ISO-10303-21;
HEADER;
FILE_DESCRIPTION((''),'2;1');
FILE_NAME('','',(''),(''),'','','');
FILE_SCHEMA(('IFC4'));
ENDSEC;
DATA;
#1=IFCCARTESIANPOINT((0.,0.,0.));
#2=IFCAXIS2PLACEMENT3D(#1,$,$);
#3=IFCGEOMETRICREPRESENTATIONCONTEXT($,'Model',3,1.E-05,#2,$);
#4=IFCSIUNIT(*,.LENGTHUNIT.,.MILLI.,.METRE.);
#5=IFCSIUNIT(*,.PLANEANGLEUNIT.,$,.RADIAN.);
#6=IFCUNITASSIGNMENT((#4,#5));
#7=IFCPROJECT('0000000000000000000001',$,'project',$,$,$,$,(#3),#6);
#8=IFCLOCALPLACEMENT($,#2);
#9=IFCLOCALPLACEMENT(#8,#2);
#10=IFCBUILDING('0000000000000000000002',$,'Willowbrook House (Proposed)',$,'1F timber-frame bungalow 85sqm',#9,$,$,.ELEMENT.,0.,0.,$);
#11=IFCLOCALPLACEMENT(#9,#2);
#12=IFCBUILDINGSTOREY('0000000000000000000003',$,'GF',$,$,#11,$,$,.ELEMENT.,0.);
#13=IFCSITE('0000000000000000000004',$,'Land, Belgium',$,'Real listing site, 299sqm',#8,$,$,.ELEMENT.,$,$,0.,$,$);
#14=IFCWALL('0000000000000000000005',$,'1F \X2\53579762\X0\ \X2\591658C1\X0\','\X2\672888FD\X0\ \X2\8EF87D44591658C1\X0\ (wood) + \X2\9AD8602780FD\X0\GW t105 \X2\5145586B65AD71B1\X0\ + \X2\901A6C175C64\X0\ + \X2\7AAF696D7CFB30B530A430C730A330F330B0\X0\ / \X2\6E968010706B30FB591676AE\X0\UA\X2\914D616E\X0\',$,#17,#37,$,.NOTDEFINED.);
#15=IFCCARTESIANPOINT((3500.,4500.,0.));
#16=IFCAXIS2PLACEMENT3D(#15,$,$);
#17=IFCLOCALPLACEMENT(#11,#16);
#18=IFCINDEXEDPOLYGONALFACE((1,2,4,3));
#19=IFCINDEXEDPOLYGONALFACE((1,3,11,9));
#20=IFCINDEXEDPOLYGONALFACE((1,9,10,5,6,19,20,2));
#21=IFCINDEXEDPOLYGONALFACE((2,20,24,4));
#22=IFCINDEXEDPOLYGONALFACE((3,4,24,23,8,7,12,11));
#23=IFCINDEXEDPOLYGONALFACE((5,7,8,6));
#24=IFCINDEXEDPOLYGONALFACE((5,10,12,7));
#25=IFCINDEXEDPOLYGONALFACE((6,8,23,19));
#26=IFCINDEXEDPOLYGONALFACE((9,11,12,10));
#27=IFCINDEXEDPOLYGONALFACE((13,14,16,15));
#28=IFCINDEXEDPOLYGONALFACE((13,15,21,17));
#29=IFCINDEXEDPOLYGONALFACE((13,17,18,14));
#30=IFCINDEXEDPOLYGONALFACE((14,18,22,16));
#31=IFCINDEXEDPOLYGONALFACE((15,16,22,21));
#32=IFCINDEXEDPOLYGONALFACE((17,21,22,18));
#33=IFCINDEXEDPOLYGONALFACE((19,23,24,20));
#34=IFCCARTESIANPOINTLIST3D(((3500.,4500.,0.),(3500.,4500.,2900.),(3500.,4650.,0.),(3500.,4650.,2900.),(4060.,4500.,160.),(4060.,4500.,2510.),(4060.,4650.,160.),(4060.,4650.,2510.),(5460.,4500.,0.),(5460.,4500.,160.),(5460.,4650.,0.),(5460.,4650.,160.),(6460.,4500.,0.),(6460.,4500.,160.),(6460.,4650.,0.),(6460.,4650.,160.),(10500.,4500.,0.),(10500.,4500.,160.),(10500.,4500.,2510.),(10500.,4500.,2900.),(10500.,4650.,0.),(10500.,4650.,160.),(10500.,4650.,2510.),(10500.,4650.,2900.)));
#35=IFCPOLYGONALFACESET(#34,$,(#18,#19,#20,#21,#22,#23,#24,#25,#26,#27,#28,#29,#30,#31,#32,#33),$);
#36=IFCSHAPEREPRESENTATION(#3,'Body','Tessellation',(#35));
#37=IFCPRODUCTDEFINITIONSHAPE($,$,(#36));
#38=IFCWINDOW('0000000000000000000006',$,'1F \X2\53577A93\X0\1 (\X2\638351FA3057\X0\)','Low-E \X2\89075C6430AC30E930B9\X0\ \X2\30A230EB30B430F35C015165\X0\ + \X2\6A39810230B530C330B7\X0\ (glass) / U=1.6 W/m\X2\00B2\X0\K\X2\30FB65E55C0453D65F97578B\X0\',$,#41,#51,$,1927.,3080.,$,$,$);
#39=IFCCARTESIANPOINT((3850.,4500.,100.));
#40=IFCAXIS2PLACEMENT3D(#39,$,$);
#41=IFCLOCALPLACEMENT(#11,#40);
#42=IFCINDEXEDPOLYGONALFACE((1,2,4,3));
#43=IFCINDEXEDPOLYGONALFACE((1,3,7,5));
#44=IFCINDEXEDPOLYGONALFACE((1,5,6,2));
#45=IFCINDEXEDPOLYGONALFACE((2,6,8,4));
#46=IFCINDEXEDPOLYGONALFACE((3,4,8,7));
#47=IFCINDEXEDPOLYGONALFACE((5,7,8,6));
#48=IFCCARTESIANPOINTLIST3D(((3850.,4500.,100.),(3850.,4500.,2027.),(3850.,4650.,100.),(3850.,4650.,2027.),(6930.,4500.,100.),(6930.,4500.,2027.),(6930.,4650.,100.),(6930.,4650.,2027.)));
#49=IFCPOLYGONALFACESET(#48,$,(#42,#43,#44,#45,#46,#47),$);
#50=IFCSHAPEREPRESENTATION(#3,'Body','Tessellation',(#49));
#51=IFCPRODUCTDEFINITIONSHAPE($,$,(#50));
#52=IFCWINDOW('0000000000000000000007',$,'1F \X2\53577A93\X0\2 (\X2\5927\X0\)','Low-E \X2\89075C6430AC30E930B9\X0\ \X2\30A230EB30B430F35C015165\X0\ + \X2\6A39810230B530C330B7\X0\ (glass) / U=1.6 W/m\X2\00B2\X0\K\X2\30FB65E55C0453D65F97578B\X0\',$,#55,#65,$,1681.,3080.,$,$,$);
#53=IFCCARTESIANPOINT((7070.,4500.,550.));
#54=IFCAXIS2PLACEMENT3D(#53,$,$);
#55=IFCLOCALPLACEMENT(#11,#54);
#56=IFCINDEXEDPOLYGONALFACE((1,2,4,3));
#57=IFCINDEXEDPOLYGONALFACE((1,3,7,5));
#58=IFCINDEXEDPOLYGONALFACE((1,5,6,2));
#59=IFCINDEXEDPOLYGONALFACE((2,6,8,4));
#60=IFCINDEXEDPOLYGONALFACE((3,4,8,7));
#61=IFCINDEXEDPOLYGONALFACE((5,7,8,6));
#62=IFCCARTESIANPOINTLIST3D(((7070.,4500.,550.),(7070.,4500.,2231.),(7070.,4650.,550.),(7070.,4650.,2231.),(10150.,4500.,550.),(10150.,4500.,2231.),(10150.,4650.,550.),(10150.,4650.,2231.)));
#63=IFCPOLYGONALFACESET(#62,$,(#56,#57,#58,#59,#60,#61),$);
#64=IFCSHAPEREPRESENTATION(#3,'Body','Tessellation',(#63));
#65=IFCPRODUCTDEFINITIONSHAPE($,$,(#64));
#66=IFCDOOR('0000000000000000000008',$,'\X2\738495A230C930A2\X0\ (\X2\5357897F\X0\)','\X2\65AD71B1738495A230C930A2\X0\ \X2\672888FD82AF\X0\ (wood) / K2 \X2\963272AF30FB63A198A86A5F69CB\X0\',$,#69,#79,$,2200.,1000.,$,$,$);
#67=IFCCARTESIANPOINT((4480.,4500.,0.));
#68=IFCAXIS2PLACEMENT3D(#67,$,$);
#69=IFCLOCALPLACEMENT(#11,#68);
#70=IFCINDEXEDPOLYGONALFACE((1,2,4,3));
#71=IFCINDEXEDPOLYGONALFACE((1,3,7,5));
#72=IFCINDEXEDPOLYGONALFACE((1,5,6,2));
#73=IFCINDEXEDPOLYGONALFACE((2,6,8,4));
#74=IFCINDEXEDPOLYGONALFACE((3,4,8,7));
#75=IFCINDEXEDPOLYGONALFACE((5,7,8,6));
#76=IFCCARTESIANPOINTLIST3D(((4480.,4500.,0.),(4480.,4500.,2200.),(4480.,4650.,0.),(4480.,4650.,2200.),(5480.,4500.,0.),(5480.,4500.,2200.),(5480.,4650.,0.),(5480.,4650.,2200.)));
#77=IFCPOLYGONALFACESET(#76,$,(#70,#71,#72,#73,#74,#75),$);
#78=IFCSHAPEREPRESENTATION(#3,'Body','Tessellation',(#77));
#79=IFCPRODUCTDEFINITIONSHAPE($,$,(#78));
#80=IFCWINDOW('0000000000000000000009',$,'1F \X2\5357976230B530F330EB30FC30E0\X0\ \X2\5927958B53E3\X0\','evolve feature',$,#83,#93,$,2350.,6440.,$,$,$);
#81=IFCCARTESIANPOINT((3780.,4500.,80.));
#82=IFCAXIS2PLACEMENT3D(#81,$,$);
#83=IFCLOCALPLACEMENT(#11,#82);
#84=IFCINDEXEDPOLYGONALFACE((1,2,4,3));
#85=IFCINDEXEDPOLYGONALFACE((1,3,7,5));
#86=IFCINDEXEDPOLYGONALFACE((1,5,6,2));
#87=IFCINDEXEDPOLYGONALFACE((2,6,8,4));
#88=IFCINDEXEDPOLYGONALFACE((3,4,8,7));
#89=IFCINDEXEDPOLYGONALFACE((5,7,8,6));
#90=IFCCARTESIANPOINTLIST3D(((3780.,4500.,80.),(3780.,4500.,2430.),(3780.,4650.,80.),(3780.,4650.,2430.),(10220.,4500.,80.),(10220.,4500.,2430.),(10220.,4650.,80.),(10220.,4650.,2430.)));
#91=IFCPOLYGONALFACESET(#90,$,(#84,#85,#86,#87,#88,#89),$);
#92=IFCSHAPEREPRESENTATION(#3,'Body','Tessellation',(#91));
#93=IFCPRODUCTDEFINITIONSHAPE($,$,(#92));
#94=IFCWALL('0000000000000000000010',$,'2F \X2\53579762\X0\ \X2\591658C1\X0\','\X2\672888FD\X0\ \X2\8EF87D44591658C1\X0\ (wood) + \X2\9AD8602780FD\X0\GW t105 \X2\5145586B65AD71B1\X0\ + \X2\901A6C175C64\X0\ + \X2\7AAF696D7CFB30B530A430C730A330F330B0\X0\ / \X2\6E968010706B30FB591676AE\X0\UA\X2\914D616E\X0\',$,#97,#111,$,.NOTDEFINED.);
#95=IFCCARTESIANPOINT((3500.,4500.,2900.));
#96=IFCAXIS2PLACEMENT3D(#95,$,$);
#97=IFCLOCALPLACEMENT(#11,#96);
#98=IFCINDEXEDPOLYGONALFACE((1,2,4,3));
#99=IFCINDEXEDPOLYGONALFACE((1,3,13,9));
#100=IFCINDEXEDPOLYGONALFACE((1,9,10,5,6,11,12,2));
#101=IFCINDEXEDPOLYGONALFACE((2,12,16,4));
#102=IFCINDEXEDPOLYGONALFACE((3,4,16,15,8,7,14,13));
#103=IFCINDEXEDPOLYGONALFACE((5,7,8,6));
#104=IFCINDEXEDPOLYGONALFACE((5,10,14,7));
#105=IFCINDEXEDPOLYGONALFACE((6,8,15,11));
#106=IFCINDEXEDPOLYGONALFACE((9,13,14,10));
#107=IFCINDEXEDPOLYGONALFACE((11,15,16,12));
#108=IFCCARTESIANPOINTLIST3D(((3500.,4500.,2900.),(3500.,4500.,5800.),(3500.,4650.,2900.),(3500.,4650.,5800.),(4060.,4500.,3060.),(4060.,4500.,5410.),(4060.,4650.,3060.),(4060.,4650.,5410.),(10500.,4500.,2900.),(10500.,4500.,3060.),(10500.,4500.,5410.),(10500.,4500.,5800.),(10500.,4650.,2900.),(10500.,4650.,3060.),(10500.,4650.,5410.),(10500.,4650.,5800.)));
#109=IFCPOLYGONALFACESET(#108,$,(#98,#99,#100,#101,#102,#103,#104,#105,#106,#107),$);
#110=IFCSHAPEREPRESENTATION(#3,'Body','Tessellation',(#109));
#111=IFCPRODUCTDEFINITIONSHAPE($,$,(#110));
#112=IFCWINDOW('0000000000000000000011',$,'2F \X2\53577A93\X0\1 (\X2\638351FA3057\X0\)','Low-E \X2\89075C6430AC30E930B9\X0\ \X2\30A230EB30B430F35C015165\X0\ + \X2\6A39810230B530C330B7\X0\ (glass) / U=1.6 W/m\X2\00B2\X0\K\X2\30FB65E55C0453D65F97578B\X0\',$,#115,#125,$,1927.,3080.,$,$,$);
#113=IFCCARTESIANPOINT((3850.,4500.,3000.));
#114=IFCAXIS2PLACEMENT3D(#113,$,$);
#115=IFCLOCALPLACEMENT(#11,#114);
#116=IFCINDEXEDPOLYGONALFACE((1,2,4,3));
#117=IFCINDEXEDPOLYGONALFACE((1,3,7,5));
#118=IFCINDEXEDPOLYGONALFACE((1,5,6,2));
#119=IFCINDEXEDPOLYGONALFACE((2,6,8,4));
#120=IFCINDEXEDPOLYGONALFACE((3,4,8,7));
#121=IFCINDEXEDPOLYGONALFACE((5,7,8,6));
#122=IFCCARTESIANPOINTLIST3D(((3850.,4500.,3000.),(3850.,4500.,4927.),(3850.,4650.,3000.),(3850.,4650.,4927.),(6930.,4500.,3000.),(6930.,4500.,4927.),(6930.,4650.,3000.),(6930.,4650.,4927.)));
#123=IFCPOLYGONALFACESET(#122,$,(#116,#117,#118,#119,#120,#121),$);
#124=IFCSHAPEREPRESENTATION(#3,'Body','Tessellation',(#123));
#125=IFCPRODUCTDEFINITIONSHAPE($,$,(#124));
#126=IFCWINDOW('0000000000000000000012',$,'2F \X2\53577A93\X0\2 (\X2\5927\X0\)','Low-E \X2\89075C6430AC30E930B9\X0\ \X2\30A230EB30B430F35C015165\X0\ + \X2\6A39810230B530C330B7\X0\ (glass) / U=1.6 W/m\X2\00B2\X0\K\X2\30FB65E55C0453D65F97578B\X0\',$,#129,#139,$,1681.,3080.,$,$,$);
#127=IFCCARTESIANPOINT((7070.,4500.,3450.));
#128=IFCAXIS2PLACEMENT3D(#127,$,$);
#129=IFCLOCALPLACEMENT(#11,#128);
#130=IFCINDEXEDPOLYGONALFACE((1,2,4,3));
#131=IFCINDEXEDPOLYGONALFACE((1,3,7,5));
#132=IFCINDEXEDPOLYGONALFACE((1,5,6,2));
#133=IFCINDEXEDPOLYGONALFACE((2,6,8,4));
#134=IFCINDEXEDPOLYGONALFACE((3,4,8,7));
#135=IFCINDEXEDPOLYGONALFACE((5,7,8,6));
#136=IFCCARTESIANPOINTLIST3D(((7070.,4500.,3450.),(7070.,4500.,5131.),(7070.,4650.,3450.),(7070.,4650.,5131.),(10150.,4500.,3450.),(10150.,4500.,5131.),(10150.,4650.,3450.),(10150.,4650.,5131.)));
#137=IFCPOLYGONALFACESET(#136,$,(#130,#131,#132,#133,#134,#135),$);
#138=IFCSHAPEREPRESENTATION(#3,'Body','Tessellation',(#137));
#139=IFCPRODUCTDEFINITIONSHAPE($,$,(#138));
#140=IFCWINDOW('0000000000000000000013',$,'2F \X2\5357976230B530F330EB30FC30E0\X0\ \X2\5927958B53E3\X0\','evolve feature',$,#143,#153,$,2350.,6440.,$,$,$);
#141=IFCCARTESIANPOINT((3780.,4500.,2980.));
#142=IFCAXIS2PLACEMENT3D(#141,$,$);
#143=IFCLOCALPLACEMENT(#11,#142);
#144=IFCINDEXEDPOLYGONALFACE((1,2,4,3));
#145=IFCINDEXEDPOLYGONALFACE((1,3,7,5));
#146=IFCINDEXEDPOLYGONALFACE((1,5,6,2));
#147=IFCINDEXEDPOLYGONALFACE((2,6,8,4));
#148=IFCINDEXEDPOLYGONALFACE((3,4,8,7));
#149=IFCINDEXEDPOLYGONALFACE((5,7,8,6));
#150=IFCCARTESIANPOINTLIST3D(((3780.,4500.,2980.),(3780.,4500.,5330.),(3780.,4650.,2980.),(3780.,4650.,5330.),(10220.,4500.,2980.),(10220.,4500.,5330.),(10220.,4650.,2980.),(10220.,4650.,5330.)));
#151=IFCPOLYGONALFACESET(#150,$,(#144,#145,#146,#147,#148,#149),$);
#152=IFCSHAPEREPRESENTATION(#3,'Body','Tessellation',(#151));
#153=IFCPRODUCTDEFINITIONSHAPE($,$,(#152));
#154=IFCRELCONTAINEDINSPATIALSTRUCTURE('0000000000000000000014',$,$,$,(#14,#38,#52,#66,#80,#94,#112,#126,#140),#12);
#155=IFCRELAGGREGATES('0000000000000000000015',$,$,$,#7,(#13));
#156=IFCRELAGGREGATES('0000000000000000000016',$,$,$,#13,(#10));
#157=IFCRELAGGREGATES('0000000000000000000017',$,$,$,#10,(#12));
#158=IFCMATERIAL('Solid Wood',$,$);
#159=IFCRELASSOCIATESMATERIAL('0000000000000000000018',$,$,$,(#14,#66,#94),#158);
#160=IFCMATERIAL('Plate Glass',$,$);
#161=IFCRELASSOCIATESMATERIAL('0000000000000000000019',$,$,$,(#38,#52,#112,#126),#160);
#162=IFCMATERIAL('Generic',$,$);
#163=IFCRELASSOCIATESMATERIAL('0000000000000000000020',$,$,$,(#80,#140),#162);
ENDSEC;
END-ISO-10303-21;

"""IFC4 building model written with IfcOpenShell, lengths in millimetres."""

from ifc_helpers import new_model, si_unit, frame, frame_2d, origin, place, context, project, spatial, rectangle, extrude, material, element, fill, save


model = new_model("IFC4")

# Units and contexts
model_context = context("Model", 3, precision=1e-05, world=origin())
ifc_project = project(units=[si_unit("LENGTHUNIT", "METRE", prefix="MILLI"), si_unit("PLANEANGLEUNIT", "RADIAN")], contexts=[model_context])

# Site, building, storey
site_placement = place(None, origin())
site = spatial("IfcSite", under=ifc_project, at=site_placement, Name="Land, Belgium", ObjectType="Real listing site, 299sqm", CompositionType="ELEMENT", RefElevation=0.0)
building_placement = place(site_placement, origin())
building = spatial("IfcBuilding", under=site, at=building_placement, Name="Willowbrook House (Proposed)", ObjectType="1F timber-frame bungalow 85sqm", CompositionType="ELEMENT", ElevationOfRefHeight=0.0, ElevationOfTerrain=0.0)
storey_placement = place(building_placement, origin())
storey = spatial("IfcBuildingStorey", under=building, at=storey_placement, Name="GF", CompositionType="ELEMENT", Elevation=0.0)

# Shared definitions
ifc_material_1 = material(Name="Solid Wood")
ifc_material_2 = material(Name="Generic")

# Wall, openings, windows, door
wall_1_placement = place(storey_placement, frame((3500.0, 4500.0, 0.0)))
wall_1 = element("IfcWall", 1, at=wall_1_placement, inside=storey, material=ifc_material_1, Name="1F 南面 外壁", Description="木製 軸組外壁 (wood) + 高性能GW t105 充填断熱 + 通気層 + 窯業系サイディング / 準耐火・外皮UA配慮", PredefinedType="NOTDEFINED", context=model_context, shape_type="SweptSolid", body=[
    extrude(rectangle(XDim=7000.0, YDim=150.0, at=frame_2d((3500.0, 75.0))), frame((3500.0, 4500.0, 0.0)), (0.0, 0.0, 1.0), 2900.0),
])
opening_1_placement = place(storey_placement, frame((3850.0, 4500.0, 100.0)))
opening_1 = element("IfcOpeningElement", 2, at=opening_1_placement, cuts=wall_1, PredefinedType="NOTDEFINED", context=model_context, shape_type="SweptSolid", body=[
    extrude(rectangle(XDim=3080.0, YDim=150.0, at=frame_2d((1540.0, 75.0))), frame((3850.0, 4500.0, 100.0)), (0.0, 0.0, 1.0), 1927.0),
])
opening_2_placement = place(storey_placement, frame((7070.0, 4500.0, 550.0)))
opening_2 = element("IfcOpeningElement", 3, at=opening_2_placement, cuts=wall_1, PredefinedType="NOTDEFINED", context=model_context, shape_type="SweptSolid", body=[
    extrude(rectangle(XDim=3080.0, YDim=150.0, at=frame_2d((1540.0, 75.0))), frame((7070.0, 4500.0, 550.0)), (0.0, 0.0, 1.0), 1681.0),
])
opening_3_placement = place(storey_placement, frame((4480.0, 4500.0, 0.0)))
opening_3 = element("IfcOpeningElement", 4, at=opening_3_placement, cuts=wall_1, PredefinedType="NOTDEFINED", context=model_context, shape_type="SweptSolid", body=[
    extrude(rectangle(XDim=1000.0, YDim=150.0, at=frame_2d((500.0, 75.0))), frame((4480.0, 4500.0, 0.0)), (0.0, 0.0, 1.0), 2200.0),
])
opening_4_placement = place(storey_placement, frame((3780.0, 4500.0, 80.0)))
opening_4 = element("IfcOpeningElement", 5, at=opening_4_placement, cuts=wall_1, PredefinedType="NOTDEFINED", context=model_context, shape_type="SweptSolid", body=[
    extrude(rectangle(XDim=6440.0, YDim=150.0, at=frame_2d((3220.0, 75.0))), frame((3780.0, 4500.0, 80.0)), (0.0, 0.0, 1.0), 2350.0),
])
ifc_material_3 = material(Name="Plate Glass")
window_1_placement = place(storey_placement, frame((3850.0, 4500.0, 100.0)))
window_1 = element("IfcWindow", 6, at=window_1_placement, inside=storey, material=ifc_material_3, Name="1F 南窓1 (掃出し)", Description="Low-E 複層ガラス アルゴン封入 + 樹脂サッシ (glass) / U=1.6 W/m²K・日射取得型", OverallHeight=1927.0, OverallWidth=3080.0, context=model_context, shape_type="SweptSolid", body=[
    extrude(rectangle(XDim=3080.0, YDim=150.0, at=frame_2d((1540.0, 75.0))), frame((3850.0, 4500.0, 100.0)), (0.0, 0.0, 1.0), 1927.0),
])
fill(opening_1, window_1)
window_2_placement = place(storey_placement, frame((7070.0, 4500.0, 550.0)))
window_2 = element("IfcWindow", 7, at=window_2_placement, inside=storey, material=ifc_material_3, Name="1F 南窓2 (大)", Description="Low-E 複層ガラス アルゴン封入 + 樹脂サッシ (glass) / U=1.6 W/m²K・日射取得型", OverallHeight=1681.0, OverallWidth=3080.0, context=model_context, shape_type="SweptSolid", body=[
    extrude(rectangle(XDim=3080.0, YDim=150.0, at=frame_2d((1540.0, 75.0))), frame((7070.0, 4500.0, 550.0)), (0.0, 0.0, 1.0), 1681.0),
])
fill(opening_2, window_2)
door_placement = place(storey_placement, frame((4480.0, 4500.0, 0.0)))
door = element("IfcDoor", 8, at=door_placement, inside=storey, material=ifc_material_1, Name="玄関ドア (南西)", Description="断熱玄関ドア 木製芯 (wood) / K2 防犯・採風機構", OverallHeight=2200.0, OverallWidth=1000.0, context=model_context, shape_type="SweptSolid", body=[
    extrude(rectangle(XDim=1000.0, YDim=150.0, at=frame_2d((500.0, 75.0))), frame((4480.0, 4500.0, 0.0)), (0.0, 0.0, 1.0), 2200.0),
])
fill(opening_3, door)
window_3_placement = place(storey_placement, frame((3780.0, 4500.0, 80.0)))
window_3 = element("IfcWindow", 9, at=window_3_placement, inside=storey, material=ifc_material_2, Name="1F 南面サンルーム 大開口", Description="evolve feature", OverallHeight=2350.0, OverallWidth=6440.0, context=model_context, shape_type="SweptSolid", body=[
    extrude(rectangle(XDim=6440.0, YDim=150.0, at=frame_2d((3220.0, 75.0))), frame((3780.0, 4500.0, 80.0)), (0.0, 0.0, 1.0), 2350.0),
])
fill(opening_4, window_3)

# Wall, openings, windows
wall_2_placement = place(storey_placement, frame((3500.0, 4500.0, 2900.0)))
wall_2 = element("IfcWall", 10, at=wall_2_placement, inside=storey, material=ifc_material_1, Name="2F 南面 外壁", Description="木製 軸組外壁 (wood) + 高性能GW t105 充填断熱 + 通気層 + 窯業系サイディング / 準耐火・外皮UA配慮", PredefinedType="NOTDEFINED", context=model_context, shape_type="SweptSolid", body=[
    extrude(rectangle(XDim=7000.0, YDim=150.0, at=frame_2d((3500.0, 75.0))), frame((3500.0, 4500.0, 2900.0)), (0.0, 0.0, 1.0), 2900.0),
])
opening_5_placement = place(storey_placement, frame((3850.0, 4500.0, 3000.0)))
opening_5 = element("IfcOpeningElement", 11, at=opening_5_placement, cuts=wall_2, PredefinedType="NOTDEFINED", context=model_context, shape_type="SweptSolid", body=[
    extrude(rectangle(XDim=3080.0, YDim=150.0, at=frame_2d((1540.0, 75.0))), frame((3850.0, 4500.0, 3000.0)), (0.0, 0.0, 1.0), 1927.0),
])
opening_6_placement = place(storey_placement, frame((7070.0, 4500.0, 3450.0)))
opening_6 = element("IfcOpeningElement", 12, at=opening_6_placement, cuts=wall_2, PredefinedType="NOTDEFINED", context=model_context, shape_type="SweptSolid", body=[
    extrude(rectangle(XDim=3080.0, YDim=150.0, at=frame_2d((1540.0, 75.0))), frame((7070.0, 4500.0, 3450.0)), (0.0, 0.0, 1.0), 1681.0),
])
opening_7_placement = place(storey_placement, frame((3780.0, 4500.0, 2980.0)))
opening_7 = element("IfcOpeningElement", 13, at=opening_7_placement, cuts=wall_2, PredefinedType="NOTDEFINED", context=model_context, shape_type="SweptSolid", body=[
    extrude(rectangle(XDim=6440.0, YDim=150.0, at=frame_2d((3220.0, 75.0))), frame((3780.0, 4500.0, 2980.0)), (0.0, 0.0, 1.0), 2350.0),
])
window_4_placement = place(storey_placement, frame((3850.0, 4500.0, 3000.0)))
window_4 = element("IfcWindow", 14, at=window_4_placement, inside=storey, material=ifc_material_3, Name="2F 南窓1 (掃出し)", Description="Low-E 複層ガラス アルゴン封入 + 樹脂サッシ (glass) / U=1.6 W/m²K・日射取得型", OverallHeight=1927.0, OverallWidth=3080.0, context=model_context, shape_type="SweptSolid", body=[
    extrude(rectangle(XDim=3080.0, YDim=150.0, at=frame_2d((1540.0, 75.0))), frame((3850.0, 4500.0, 3000.0)), (0.0, 0.0, 1.0), 1927.0),
])
fill(opening_5, window_4)
window_5_placement = place(storey_placement, frame((7070.0, 4500.0, 3450.0)))
window_5 = element("IfcWindow", 15, at=window_5_placement, inside=storey, material=ifc_material_3, Name="2F 南窓2 (大)", Description="Low-E 複層ガラス アルゴン封入 + 樹脂サッシ (glass) / U=1.6 W/m²K・日射取得型", OverallHeight=1681.0, OverallWidth=3080.0, context=model_context, shape_type="SweptSolid", body=[
    extrude(rectangle(XDim=3080.0, YDim=150.0, at=frame_2d((1540.0, 75.0))), frame((7070.0, 4500.0, 3450.0)), (0.0, 0.0, 1.0), 1681.0),
])
fill(opening_6, window_5)
window_6_placement = place(storey_placement, frame((3780.0, 4500.0, 2980.0)))
window_6 = element("IfcWindow", 16, at=window_6_placement, inside=storey, material=ifc_material_2, Name="2F 南面サンルーム 大開口", Description="evolve feature", OverallHeight=2350.0, OverallWidth=6440.0, context=model_context, shape_type="SweptSolid", body=[
    extrude(rectangle(XDim=6440.0, YDim=150.0, at=frame_2d((3220.0, 75.0))), frame((3780.0, 4500.0, 2980.0)), (0.0, 0.0, 1.0), 2350.0),
])
fill(opening_7, window_6)

save(model, "model.ifc")
